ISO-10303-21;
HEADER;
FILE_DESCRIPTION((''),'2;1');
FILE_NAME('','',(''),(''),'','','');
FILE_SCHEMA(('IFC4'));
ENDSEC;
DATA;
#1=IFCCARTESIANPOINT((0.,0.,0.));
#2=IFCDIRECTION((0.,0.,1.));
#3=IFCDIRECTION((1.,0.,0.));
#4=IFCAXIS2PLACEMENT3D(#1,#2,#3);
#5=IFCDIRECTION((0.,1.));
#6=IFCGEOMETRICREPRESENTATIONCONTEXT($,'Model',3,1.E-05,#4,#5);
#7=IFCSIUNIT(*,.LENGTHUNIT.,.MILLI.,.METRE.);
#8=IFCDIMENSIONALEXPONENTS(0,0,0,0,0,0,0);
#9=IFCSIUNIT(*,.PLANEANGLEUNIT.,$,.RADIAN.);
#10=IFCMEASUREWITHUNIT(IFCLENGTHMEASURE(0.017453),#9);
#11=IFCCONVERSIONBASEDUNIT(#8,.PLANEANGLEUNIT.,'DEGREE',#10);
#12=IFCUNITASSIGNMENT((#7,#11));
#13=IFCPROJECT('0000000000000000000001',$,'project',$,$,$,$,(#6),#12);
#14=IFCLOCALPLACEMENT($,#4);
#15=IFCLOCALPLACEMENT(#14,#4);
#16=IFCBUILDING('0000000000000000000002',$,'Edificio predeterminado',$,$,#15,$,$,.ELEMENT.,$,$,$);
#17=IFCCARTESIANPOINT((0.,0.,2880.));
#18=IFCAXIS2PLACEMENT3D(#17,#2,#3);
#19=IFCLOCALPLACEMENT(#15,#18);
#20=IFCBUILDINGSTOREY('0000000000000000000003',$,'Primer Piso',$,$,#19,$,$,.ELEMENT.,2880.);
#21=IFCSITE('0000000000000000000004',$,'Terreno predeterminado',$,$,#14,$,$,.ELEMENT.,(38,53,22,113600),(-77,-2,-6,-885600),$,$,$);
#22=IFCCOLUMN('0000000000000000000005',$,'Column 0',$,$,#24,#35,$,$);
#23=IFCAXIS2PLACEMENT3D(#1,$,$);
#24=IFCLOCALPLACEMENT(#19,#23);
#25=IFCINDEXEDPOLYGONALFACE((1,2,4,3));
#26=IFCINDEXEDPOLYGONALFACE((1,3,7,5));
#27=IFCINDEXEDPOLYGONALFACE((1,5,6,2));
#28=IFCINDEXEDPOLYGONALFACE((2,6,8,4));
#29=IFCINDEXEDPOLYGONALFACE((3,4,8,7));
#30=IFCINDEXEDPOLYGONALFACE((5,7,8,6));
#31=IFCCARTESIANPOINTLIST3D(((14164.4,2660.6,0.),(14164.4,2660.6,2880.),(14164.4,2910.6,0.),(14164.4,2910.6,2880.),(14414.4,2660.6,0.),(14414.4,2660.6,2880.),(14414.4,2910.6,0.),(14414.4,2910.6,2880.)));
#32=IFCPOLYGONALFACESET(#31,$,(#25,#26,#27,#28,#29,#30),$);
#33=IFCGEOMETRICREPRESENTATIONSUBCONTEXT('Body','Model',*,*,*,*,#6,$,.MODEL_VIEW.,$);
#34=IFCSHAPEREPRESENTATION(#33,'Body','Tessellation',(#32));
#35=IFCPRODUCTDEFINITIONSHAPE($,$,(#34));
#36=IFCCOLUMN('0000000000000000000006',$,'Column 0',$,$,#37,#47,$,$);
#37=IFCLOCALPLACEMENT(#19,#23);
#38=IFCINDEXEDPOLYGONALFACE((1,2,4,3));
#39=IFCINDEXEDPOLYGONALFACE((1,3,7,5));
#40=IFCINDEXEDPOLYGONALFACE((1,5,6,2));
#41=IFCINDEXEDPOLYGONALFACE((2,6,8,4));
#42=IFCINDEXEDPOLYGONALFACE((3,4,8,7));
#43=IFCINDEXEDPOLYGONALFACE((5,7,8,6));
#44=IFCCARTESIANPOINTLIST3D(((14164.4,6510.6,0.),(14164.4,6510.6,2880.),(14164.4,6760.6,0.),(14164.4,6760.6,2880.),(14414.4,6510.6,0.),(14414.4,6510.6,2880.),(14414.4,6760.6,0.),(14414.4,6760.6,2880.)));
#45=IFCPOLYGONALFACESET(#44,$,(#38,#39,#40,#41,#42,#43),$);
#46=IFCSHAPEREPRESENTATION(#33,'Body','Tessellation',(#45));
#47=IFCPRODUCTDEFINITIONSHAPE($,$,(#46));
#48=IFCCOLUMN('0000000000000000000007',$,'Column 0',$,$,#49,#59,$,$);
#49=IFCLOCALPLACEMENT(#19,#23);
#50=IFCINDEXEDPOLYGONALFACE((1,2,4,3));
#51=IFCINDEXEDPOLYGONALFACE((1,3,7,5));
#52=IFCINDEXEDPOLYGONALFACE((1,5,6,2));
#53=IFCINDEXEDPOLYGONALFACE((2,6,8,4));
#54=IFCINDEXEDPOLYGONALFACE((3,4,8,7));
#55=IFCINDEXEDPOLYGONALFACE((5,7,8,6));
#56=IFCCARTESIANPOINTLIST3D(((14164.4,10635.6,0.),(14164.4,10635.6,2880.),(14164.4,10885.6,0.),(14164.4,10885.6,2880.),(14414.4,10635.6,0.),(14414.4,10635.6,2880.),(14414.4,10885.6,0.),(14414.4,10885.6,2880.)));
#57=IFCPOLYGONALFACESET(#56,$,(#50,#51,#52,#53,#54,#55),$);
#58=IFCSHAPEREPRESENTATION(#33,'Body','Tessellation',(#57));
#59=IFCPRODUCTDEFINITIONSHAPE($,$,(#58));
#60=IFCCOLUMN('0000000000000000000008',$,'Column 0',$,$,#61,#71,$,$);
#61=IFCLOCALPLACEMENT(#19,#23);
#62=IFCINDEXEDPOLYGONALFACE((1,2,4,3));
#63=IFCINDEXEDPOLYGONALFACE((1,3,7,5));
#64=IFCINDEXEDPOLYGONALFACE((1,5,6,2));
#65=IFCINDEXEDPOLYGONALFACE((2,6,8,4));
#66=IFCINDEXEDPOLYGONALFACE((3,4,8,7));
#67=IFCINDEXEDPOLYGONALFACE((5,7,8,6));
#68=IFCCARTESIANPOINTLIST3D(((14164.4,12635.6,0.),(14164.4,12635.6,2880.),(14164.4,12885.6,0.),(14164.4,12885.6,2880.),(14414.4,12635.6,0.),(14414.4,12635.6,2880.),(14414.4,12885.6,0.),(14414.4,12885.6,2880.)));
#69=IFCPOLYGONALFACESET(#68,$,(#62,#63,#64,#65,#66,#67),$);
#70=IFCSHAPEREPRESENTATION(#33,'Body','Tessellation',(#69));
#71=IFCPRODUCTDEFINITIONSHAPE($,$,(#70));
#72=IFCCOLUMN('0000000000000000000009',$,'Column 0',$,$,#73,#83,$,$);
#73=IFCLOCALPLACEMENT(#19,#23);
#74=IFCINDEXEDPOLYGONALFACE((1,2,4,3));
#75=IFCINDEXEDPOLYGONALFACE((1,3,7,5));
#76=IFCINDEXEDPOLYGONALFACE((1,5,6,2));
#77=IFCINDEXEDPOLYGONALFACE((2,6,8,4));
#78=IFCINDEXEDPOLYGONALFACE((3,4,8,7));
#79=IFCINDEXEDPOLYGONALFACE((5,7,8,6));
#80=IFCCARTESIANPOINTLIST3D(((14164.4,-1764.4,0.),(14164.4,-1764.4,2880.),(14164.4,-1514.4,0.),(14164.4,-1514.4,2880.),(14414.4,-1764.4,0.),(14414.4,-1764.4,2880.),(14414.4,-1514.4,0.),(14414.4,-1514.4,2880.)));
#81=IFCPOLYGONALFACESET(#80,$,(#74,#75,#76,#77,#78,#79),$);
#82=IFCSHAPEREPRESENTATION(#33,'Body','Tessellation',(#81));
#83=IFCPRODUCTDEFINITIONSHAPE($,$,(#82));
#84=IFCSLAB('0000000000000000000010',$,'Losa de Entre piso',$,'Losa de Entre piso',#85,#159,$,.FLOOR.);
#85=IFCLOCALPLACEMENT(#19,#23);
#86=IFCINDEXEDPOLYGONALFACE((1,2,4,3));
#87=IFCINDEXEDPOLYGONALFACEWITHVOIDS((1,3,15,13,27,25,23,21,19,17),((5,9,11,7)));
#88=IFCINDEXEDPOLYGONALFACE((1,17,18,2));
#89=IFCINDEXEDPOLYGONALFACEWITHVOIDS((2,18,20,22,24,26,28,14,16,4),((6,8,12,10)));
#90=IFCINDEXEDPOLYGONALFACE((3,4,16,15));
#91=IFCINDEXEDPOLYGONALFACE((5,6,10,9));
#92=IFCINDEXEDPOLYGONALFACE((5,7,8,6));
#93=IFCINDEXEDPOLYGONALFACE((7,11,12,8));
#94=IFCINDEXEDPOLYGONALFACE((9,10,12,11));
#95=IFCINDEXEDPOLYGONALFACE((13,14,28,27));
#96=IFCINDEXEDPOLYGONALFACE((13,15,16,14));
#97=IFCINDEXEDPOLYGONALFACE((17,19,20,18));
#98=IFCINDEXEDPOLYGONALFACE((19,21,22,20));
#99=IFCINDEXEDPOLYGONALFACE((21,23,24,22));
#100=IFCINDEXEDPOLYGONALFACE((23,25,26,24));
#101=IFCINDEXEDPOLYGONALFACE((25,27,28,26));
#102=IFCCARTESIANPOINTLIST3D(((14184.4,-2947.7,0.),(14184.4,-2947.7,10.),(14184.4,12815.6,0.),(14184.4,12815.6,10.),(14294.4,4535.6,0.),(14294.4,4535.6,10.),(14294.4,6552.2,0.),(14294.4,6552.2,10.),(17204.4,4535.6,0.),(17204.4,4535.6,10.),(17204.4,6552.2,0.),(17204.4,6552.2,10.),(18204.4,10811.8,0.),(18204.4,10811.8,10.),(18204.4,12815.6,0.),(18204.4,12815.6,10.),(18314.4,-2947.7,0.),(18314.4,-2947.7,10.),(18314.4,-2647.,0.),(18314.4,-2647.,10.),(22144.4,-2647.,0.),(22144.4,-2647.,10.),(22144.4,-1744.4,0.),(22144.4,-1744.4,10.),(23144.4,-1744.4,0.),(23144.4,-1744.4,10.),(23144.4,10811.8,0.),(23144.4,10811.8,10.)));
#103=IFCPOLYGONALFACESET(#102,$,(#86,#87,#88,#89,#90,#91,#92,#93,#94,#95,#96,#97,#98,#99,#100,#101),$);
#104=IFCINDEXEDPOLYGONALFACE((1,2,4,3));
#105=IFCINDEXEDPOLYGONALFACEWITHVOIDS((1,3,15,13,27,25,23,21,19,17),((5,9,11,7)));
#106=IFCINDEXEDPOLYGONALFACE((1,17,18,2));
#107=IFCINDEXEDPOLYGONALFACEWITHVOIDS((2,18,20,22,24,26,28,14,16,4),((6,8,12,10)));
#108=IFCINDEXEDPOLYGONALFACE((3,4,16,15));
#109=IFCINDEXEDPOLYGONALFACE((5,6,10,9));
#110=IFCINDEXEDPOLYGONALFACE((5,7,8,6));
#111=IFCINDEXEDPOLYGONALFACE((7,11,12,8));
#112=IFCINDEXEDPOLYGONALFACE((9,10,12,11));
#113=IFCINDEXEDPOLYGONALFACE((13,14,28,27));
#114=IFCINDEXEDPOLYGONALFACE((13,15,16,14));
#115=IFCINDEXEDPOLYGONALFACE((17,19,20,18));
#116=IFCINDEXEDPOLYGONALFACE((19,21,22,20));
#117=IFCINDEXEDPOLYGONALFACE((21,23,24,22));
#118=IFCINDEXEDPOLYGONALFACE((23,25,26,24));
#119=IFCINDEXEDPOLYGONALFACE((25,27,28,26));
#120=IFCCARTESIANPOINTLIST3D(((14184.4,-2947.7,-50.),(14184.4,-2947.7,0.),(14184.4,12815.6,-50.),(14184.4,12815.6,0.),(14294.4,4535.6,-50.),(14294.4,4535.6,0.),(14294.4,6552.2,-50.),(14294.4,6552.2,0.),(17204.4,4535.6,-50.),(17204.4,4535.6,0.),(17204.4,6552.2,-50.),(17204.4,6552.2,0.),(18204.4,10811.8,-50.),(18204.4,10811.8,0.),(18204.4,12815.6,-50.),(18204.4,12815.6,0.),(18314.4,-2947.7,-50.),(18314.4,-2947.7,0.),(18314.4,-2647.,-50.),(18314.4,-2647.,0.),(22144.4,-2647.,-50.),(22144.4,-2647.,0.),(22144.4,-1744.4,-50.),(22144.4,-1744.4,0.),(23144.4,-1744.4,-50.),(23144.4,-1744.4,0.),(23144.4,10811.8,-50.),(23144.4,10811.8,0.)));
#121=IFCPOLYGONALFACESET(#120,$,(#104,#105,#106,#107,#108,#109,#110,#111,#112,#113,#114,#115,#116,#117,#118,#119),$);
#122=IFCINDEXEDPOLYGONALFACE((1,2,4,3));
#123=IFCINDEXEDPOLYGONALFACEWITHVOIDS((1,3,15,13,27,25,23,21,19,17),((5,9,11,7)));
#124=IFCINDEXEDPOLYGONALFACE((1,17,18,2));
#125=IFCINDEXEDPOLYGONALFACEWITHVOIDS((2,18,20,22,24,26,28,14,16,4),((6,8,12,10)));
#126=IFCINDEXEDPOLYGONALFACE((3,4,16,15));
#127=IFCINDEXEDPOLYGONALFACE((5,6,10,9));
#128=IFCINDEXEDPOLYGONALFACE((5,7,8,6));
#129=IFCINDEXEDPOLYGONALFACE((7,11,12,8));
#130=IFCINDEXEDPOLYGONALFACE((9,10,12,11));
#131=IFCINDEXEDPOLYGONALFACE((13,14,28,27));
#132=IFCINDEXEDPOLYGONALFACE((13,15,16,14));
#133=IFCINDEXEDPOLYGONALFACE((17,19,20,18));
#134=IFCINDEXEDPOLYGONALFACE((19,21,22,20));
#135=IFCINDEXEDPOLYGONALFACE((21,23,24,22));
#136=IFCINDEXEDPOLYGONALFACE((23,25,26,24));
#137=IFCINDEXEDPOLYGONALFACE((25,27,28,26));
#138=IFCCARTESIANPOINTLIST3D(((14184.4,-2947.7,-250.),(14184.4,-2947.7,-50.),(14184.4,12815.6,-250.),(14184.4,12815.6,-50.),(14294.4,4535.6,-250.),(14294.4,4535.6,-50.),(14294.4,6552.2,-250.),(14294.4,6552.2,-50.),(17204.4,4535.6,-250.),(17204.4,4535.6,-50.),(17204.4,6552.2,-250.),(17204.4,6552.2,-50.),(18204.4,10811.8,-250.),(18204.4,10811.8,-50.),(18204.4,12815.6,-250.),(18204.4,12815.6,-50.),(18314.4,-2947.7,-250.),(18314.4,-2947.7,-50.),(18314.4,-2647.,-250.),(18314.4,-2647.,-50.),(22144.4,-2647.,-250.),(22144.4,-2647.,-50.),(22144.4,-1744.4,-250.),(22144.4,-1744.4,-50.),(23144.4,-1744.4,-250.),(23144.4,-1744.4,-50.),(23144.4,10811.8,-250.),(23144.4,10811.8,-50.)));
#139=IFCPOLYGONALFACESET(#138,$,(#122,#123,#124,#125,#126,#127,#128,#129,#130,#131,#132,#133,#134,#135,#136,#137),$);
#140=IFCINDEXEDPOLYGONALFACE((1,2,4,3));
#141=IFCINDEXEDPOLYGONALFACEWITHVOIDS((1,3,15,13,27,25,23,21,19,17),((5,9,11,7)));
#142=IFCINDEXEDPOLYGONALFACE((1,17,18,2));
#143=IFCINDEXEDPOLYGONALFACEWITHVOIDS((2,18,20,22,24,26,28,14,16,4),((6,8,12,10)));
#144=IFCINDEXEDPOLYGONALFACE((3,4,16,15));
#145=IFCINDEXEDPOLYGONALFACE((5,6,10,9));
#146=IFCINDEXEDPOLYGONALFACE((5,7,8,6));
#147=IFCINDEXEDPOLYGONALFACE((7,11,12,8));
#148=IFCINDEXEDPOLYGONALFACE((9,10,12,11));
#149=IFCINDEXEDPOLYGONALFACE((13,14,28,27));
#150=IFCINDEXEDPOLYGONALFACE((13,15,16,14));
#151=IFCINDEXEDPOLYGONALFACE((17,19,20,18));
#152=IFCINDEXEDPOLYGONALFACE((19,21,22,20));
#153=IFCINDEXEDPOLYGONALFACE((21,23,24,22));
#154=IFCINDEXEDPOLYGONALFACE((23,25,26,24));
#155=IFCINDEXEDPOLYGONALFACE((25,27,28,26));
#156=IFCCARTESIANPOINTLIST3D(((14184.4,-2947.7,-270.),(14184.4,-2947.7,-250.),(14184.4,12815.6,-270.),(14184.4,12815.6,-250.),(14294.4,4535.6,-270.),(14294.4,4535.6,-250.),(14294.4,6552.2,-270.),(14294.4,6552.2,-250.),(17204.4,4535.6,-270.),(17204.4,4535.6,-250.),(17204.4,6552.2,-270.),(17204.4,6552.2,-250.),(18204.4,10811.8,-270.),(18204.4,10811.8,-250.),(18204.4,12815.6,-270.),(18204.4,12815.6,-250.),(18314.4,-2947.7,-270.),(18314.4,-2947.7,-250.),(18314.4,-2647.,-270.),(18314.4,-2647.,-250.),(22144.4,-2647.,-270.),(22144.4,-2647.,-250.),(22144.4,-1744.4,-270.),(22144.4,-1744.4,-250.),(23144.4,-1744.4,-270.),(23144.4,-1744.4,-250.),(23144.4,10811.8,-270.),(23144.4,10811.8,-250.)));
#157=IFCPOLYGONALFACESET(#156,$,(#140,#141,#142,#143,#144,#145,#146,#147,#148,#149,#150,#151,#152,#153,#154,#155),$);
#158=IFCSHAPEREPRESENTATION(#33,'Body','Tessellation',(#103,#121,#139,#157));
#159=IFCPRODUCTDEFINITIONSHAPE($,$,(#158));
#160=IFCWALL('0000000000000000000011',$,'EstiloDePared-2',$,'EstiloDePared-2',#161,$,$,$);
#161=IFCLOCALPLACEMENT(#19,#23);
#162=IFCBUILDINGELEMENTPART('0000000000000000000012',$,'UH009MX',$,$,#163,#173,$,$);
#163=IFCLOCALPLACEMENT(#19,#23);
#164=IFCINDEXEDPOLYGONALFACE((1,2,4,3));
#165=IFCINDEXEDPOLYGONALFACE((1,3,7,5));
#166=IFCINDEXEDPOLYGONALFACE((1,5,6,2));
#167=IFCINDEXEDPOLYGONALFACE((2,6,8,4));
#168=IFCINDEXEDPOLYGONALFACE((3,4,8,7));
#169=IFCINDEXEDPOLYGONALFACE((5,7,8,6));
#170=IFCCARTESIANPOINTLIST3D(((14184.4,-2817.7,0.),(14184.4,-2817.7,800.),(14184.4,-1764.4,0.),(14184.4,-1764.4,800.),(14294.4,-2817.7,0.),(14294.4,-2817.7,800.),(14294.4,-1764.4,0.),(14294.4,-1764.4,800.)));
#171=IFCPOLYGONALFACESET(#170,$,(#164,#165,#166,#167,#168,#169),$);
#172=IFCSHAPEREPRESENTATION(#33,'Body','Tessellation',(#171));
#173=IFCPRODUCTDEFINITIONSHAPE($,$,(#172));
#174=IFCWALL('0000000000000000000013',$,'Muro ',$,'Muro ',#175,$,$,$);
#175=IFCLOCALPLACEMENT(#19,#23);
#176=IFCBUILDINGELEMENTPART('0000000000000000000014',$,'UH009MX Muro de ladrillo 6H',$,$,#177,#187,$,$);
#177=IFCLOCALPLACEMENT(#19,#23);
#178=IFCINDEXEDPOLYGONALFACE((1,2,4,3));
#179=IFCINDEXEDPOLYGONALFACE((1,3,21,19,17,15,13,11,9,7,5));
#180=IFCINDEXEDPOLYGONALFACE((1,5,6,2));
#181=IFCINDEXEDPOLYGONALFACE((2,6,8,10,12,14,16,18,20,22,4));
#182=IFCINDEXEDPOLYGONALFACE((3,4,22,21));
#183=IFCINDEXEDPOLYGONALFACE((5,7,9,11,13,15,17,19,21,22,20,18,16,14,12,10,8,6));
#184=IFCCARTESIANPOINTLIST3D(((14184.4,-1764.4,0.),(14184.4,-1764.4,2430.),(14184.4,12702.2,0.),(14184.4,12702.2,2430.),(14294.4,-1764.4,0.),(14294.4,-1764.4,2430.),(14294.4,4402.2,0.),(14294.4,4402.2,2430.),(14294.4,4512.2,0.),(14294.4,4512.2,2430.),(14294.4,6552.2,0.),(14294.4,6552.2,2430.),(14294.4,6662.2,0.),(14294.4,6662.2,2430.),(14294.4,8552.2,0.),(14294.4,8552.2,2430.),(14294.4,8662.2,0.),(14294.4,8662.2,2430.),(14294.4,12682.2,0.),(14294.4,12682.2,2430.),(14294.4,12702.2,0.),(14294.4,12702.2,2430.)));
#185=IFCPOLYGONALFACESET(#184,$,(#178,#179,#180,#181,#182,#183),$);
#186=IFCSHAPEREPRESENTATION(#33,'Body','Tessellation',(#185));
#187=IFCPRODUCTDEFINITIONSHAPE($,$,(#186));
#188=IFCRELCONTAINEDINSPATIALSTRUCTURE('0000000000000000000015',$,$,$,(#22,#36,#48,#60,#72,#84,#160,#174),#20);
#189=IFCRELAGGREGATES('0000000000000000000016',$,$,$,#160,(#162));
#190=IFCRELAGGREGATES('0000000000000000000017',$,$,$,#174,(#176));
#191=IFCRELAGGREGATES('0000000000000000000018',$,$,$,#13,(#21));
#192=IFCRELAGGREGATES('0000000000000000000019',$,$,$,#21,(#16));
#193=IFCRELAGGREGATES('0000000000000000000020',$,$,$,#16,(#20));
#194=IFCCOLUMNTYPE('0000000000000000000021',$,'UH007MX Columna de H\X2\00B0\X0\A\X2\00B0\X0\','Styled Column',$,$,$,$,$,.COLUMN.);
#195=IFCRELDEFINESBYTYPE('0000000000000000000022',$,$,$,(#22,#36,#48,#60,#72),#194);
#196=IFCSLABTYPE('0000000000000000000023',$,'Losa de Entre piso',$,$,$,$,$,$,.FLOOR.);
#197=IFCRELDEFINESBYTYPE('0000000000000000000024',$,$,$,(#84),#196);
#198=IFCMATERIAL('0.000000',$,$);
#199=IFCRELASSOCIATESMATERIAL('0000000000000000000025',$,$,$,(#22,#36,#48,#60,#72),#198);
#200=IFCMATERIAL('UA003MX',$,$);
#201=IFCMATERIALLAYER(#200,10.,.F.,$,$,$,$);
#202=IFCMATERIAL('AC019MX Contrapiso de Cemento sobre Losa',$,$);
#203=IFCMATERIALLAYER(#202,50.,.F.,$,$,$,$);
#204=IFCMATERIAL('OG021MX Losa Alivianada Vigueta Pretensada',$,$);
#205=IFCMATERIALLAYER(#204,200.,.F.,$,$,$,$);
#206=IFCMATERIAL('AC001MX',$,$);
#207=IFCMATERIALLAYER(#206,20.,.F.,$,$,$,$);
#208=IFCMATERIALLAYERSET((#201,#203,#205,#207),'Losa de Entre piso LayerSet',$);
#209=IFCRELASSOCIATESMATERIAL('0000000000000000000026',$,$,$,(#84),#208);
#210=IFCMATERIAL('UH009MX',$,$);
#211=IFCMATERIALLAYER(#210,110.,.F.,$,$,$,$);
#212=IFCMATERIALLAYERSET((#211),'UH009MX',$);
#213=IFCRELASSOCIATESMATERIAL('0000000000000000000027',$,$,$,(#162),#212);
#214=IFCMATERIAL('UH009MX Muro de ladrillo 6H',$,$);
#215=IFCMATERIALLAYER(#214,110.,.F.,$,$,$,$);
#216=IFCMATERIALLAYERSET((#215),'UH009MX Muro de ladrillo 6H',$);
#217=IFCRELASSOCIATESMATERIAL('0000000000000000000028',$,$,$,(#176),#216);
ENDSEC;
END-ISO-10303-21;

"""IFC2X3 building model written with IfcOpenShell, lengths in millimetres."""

from ifc_helpers import new_model, entity, si_unit, converted_unit, direction, frame, origin_with_axes, place, context, subcontext, project, spatial, polyline, outline, extrude, material, layer, layer_set, layer_usage, type_object, element, aggregate, save


model = new_model("IFC2X3")

# Units and contexts
model_context = context("Model", 3, precision=1e-05, world=origin_with_axes(), true_north=direction((0.0, 1.0)))
body_context = subcontext(model_context, "Body", "Model", "MODEL_VIEW")
ifc_project = project(units=[si_unit("LENGTHUNIT", "METRE", prefix="MILLI"), converted_unit("PLANEANGLEUNIT", "DEGREE", entity("IfcLengthMeasure", 0.017453), si_unit("PLANEANGLEUNIT", "RADIAN"), dimensions=[0, 0, 0, 0, 0, 0, 0])], contexts=[model_context])

# Site, building, storey
site_placement = place(None, origin_with_axes())
site = spatial("IfcSite", under=ifc_project, at=site_placement, Name="Terreno predeterminado", CompositionType="ELEMENT", RefLatitude=(38, 53, 22, 113600), RefLongitude=(-77, -2, -6, -885600))
building_placement = place(site_placement, origin_with_axes())
building = spatial("IfcBuilding", under=site, at=building_placement, Name="Edificio predeterminado", CompositionType="ELEMENT")
storey_placement = place(building_placement, frame((0.0, 0.0, 2880.0), z_axis=(0.0, 0.0, 1.0), x_axis=(1.0, 0.0, 0.0)))
storey = spatial("IfcBuildingStorey", under=building, at=storey_placement, Name="Primer Piso", CompositionType="ELEMENT", Elevation=2880.0)

# Columns
ifc_material_1 = material(Name="0.000000")
column_type = type_object("IfcColumnType", Name="UH007MX Columna de H°A°", Description="Styled Column", PredefinedType="COLUMN")
for number, where, z_axis, x_axis, name in (
    (1, (14289.4, 2785.6, 0.0), (0.0, 0.0, 1.0), (1.0, 0.0, 0.0), "Column 0"),
    (2, (14289.4, 6635.6, 0.0), (0.0, 0.0, 1.0), (1.0, 0.0, 0.0), "Column 0"),
    (3, (14289.4, 10760.6, 0.0), (0.0, 0.0, 1.0), (1.0, 0.0, 0.0), "Column 0"),
    (4, (14289.4, 12760.6, 0.0), (0.0, 0.0, 1.0), (1.0, 0.0, 0.0), "Column 0"),
    (5, (14289.4, -1639.4, 0.0), (0.0, 0.0, 1.0), (1.0, 0.0, 0.0), "Column 0"),
):
    element("IfcColumn", number, at=place(storey_placement, frame(where, z_axis=z_axis, x_axis=x_axis)), inside=storey, type_object=column_type, material=ifc_material_1, Name=name, context=body_context, shape_type="SweptSolid", body=[
        extrude(outline(polyline([(-125.0, -125.0), (125.0, -125.0), (125.0, 125.0), (-125.0, 125.0), (-125.0, -125.0)])), origin_with_axes(), (0.0, 0.0, 1.0), 2880.0),
    ])

# Slab
ifc_material_2 = material(Name="UA003MX")
ifc_layer_1 = layer(ifc_material_2, 10.0, ventilated=False)
ifc_material_3 = material(Name="AC019MX Contrapiso de Cemento sobre Losa")
ifc_layer_2 = layer(ifc_material_3, 50.0, ventilated=False)
ifc_material_4 = material(Name="OG021MX Losa Alivianada Vigueta Pretensada")
ifc_layer_3 = layer(ifc_material_4, 200.0, ventilated=False)
ifc_material_5 = material(Name="AC001MX")
ifc_layer_4 = layer(ifc_material_5, 20.0, ventilated=False)
ifc_layer_set_1 = layer_set([ifc_layer_1, ifc_layer_2, ifc_layer_3, ifc_layer_4], Name="Losa de Entre piso LayerSet")
ifc_layer_usage_1 = layer_usage(ifc_layer_set_1, "AXIS3", "NEGATIVE", 0.0)
slab_type = type_object("IfcSlabType", Name="Losa de Entre piso", PredefinedType="FLOOR")
slab_placement = place(storey_placement, frame((0.0, 0.0, -2880.0), z_axis=(0.0, 0.0, 1.0), x_axis=(1.0, 0.0, 0.0)))
element("IfcSlab", 6, at=slab_placement, inside=storey, type_object=slab_type, material=ifc_layer_usage_1, Name="Losa de Entre piso", ObjectType="Losa de Entre piso", PredefinedType="FLOOR", context=body_context, shape_type="SweptSolid", body=[
    extrude(outline(polyline([(0.0, 15763.4), (4130.0, 15763.4), (4130.0, 15462.6), (7960.0, 15462.6), (7960.0, 14560.0), (8960.0, 14560.0), (8960.0, 2003.8), (4020.0, 2003.8), (4020.0, 0.0), (0.0, 0.0), (0.0, 15763.4)]), holes=[polyline([(110.0, 6263.4), (3020.0, 6263.4), (3020.0, 8280.0), (110.0, 8280.0), (110.0, 6263.4)])]), frame((14184.4, 12815.6, 2880.0), z_axis=(0.0, 0.0, -1.0), x_axis=(1.0, 0.0, 0.0)), (0.0, 0.0, -1.0), 10.0),
    extrude(outline(polyline([(0.0, 15763.4), (4130.0, 15763.4), (4130.0, 15462.6), (7960.0, 15462.6), (7960.0, 14560.0), (8960.0, 14560.0), (8960.0, 2003.8), (4020.0, 2003.8), (4020.0, 0.0), (0.0, 0.0), (0.0, 15763.4)]), holes=[polyline([(110.0, 6263.4), (3020.0, 6263.4), (3020.0, 8280.0), (110.0, 8280.0), (110.0, 6263.4)])]), frame((14184.4, 12815.6, 2830.0), z_axis=(0.0, 0.0, -1.0), x_axis=(1.0, 0.0, 0.0)), (0.0, 0.0, -1.0), 50.0),
    extrude(outline(polyline([(0.0, 15763.4), (4130.0, 15763.4), (4130.0, 15462.6), (7960.0, 15462.6), (7960.0, 14560.0), (8960.0, 14560.0), (8960.0, 2003.8), (4020.0, 2003.8), (4020.0, 0.0), (0.0, 0.0), (0.0, 15763.4)]), holes=[polyline([(110.0, 6263.4), (3020.0, 6263.4), (3020.0, 8280.0), (110.0, 8280.0), (110.0, 6263.4)])]), frame((14184.4, 12815.6, 2630.0), z_axis=(0.0, 0.0, -1.0), x_axis=(1.0, 0.0, 0.0)), (0.0, 0.0, -1.0), 200.0),
    extrude(outline(polyline([(0.0, 15763.4), (4130.0, 15763.4), (4130.0, 15462.6), (7960.0, 15462.6), (7960.0, 14560.0), (8960.0, 14560.0), (8960.0, 2003.8), (4020.0, 2003.8), (4020.0, 0.0), (0.0, 0.0), (0.0, 15763.4)]), holes=[polyline([(110.0, 6263.4), (3020.0, 6263.4), (3020.0, 8280.0), (110.0, 8280.0), (110.0, 6263.4)])]), frame((14184.4, 12815.6, 2610.0), z_axis=(0.0, 0.0, -1.0), x_axis=(1.0, 0.0, 0.0)), (0.0, 0.0, -1.0), 20.0),
])

# Walls, building element parts
wall_1_placement = place(storey_placement, frame((14239.4, -2817.7, 0.0), z_axis=(0.0, 0.0, 1.0), x_axis=(0.0, 1.0, 0.0)))
wall_1 = element("IfcWall", 7, at=wall_1_placement, inside=storey, Name="EstiloDePared-2", ObjectType="EstiloDePared-2")
ifc_material_6 = material(Name="UH009MX")
ifc_layer_5 = layer(ifc_material_6, 110.0, ventilated=False)
ifc_layer_set_2 = layer_set([ifc_layer_5], Name="UH009MX")
ifc_layer_usage_2 = layer_usage(ifc_layer_set_2, "AXIS2", "NEGATIVE", -55.0)
building_element_part_1_placement = place(wall_1_placement, origin_with_axes())
building_element_part_1 = element("IfcBuildingElementPart", 8, at=building_element_part_1_placement, material=ifc_layer_usage_2, Name="UH009MX", context=body_context, shape_type="SweptSolid", body=[
    extrude(outline(polyline([(1053.4, 55.0), (1053.4, -55.0), (0.0, -55.0), (0.0, 55.0), (1053.4, 55.0)])), origin_with_axes(), (0.0, 0.0, 1.0), 800.0),
])
aggregate(wall_1, [building_element_part_1])
wall_2_placement = place(storey_placement, frame((14239.4, -1764.4, 0.0), z_axis=(0.0, 0.0, 1.0), x_axis=(0.0, 1.0, 0.0)))
wall_2 = element("IfcWall", 9, at=wall_2_placement, inside=storey, Name="Muro ", ObjectType="Muro ")
ifc_material_7 = material(Name="UH009MX Muro de ladrillo 6H")
ifc_layer_6 = layer(ifc_material_7, 110.0, ventilated=False)
ifc_layer_set_3 = layer_set([ifc_layer_6], Name="UH009MX Muro de ladrillo 6H")
ifc_layer_usage_3 = layer_usage(ifc_layer_set_3, "AXIS2", "NEGATIVE", -55.0)
building_element_part_2_placement = place(wall_2_placement, origin_with_axes())
building_element_part_2 = element("IfcBuildingElementPart", 10, at=building_element_part_2_placement, material=ifc_layer_usage_3, Name="UH009MX Muro de ladrillo 6H", context=body_context, shape_type="SweptSolid", body=[
    extrude(outline(polyline([(14466.6, 55.0), (14466.6, -55.0), (14446.6, -55.0), (10426.6, -55.0), (10316.6, -55.0), (8426.6, -55.0), (8316.6, -55.0), (6276.6, -55.0), (6166.6, -55.0), (0.0, -55.0), (0.0, 55.0), (14466.6, 55.0)])), origin_with_axes(), (0.0, 0.0, 1.0), 2430.0),
])
aggregate(wall_2, [building_element_part_2])

save(model, "model.ifc")
